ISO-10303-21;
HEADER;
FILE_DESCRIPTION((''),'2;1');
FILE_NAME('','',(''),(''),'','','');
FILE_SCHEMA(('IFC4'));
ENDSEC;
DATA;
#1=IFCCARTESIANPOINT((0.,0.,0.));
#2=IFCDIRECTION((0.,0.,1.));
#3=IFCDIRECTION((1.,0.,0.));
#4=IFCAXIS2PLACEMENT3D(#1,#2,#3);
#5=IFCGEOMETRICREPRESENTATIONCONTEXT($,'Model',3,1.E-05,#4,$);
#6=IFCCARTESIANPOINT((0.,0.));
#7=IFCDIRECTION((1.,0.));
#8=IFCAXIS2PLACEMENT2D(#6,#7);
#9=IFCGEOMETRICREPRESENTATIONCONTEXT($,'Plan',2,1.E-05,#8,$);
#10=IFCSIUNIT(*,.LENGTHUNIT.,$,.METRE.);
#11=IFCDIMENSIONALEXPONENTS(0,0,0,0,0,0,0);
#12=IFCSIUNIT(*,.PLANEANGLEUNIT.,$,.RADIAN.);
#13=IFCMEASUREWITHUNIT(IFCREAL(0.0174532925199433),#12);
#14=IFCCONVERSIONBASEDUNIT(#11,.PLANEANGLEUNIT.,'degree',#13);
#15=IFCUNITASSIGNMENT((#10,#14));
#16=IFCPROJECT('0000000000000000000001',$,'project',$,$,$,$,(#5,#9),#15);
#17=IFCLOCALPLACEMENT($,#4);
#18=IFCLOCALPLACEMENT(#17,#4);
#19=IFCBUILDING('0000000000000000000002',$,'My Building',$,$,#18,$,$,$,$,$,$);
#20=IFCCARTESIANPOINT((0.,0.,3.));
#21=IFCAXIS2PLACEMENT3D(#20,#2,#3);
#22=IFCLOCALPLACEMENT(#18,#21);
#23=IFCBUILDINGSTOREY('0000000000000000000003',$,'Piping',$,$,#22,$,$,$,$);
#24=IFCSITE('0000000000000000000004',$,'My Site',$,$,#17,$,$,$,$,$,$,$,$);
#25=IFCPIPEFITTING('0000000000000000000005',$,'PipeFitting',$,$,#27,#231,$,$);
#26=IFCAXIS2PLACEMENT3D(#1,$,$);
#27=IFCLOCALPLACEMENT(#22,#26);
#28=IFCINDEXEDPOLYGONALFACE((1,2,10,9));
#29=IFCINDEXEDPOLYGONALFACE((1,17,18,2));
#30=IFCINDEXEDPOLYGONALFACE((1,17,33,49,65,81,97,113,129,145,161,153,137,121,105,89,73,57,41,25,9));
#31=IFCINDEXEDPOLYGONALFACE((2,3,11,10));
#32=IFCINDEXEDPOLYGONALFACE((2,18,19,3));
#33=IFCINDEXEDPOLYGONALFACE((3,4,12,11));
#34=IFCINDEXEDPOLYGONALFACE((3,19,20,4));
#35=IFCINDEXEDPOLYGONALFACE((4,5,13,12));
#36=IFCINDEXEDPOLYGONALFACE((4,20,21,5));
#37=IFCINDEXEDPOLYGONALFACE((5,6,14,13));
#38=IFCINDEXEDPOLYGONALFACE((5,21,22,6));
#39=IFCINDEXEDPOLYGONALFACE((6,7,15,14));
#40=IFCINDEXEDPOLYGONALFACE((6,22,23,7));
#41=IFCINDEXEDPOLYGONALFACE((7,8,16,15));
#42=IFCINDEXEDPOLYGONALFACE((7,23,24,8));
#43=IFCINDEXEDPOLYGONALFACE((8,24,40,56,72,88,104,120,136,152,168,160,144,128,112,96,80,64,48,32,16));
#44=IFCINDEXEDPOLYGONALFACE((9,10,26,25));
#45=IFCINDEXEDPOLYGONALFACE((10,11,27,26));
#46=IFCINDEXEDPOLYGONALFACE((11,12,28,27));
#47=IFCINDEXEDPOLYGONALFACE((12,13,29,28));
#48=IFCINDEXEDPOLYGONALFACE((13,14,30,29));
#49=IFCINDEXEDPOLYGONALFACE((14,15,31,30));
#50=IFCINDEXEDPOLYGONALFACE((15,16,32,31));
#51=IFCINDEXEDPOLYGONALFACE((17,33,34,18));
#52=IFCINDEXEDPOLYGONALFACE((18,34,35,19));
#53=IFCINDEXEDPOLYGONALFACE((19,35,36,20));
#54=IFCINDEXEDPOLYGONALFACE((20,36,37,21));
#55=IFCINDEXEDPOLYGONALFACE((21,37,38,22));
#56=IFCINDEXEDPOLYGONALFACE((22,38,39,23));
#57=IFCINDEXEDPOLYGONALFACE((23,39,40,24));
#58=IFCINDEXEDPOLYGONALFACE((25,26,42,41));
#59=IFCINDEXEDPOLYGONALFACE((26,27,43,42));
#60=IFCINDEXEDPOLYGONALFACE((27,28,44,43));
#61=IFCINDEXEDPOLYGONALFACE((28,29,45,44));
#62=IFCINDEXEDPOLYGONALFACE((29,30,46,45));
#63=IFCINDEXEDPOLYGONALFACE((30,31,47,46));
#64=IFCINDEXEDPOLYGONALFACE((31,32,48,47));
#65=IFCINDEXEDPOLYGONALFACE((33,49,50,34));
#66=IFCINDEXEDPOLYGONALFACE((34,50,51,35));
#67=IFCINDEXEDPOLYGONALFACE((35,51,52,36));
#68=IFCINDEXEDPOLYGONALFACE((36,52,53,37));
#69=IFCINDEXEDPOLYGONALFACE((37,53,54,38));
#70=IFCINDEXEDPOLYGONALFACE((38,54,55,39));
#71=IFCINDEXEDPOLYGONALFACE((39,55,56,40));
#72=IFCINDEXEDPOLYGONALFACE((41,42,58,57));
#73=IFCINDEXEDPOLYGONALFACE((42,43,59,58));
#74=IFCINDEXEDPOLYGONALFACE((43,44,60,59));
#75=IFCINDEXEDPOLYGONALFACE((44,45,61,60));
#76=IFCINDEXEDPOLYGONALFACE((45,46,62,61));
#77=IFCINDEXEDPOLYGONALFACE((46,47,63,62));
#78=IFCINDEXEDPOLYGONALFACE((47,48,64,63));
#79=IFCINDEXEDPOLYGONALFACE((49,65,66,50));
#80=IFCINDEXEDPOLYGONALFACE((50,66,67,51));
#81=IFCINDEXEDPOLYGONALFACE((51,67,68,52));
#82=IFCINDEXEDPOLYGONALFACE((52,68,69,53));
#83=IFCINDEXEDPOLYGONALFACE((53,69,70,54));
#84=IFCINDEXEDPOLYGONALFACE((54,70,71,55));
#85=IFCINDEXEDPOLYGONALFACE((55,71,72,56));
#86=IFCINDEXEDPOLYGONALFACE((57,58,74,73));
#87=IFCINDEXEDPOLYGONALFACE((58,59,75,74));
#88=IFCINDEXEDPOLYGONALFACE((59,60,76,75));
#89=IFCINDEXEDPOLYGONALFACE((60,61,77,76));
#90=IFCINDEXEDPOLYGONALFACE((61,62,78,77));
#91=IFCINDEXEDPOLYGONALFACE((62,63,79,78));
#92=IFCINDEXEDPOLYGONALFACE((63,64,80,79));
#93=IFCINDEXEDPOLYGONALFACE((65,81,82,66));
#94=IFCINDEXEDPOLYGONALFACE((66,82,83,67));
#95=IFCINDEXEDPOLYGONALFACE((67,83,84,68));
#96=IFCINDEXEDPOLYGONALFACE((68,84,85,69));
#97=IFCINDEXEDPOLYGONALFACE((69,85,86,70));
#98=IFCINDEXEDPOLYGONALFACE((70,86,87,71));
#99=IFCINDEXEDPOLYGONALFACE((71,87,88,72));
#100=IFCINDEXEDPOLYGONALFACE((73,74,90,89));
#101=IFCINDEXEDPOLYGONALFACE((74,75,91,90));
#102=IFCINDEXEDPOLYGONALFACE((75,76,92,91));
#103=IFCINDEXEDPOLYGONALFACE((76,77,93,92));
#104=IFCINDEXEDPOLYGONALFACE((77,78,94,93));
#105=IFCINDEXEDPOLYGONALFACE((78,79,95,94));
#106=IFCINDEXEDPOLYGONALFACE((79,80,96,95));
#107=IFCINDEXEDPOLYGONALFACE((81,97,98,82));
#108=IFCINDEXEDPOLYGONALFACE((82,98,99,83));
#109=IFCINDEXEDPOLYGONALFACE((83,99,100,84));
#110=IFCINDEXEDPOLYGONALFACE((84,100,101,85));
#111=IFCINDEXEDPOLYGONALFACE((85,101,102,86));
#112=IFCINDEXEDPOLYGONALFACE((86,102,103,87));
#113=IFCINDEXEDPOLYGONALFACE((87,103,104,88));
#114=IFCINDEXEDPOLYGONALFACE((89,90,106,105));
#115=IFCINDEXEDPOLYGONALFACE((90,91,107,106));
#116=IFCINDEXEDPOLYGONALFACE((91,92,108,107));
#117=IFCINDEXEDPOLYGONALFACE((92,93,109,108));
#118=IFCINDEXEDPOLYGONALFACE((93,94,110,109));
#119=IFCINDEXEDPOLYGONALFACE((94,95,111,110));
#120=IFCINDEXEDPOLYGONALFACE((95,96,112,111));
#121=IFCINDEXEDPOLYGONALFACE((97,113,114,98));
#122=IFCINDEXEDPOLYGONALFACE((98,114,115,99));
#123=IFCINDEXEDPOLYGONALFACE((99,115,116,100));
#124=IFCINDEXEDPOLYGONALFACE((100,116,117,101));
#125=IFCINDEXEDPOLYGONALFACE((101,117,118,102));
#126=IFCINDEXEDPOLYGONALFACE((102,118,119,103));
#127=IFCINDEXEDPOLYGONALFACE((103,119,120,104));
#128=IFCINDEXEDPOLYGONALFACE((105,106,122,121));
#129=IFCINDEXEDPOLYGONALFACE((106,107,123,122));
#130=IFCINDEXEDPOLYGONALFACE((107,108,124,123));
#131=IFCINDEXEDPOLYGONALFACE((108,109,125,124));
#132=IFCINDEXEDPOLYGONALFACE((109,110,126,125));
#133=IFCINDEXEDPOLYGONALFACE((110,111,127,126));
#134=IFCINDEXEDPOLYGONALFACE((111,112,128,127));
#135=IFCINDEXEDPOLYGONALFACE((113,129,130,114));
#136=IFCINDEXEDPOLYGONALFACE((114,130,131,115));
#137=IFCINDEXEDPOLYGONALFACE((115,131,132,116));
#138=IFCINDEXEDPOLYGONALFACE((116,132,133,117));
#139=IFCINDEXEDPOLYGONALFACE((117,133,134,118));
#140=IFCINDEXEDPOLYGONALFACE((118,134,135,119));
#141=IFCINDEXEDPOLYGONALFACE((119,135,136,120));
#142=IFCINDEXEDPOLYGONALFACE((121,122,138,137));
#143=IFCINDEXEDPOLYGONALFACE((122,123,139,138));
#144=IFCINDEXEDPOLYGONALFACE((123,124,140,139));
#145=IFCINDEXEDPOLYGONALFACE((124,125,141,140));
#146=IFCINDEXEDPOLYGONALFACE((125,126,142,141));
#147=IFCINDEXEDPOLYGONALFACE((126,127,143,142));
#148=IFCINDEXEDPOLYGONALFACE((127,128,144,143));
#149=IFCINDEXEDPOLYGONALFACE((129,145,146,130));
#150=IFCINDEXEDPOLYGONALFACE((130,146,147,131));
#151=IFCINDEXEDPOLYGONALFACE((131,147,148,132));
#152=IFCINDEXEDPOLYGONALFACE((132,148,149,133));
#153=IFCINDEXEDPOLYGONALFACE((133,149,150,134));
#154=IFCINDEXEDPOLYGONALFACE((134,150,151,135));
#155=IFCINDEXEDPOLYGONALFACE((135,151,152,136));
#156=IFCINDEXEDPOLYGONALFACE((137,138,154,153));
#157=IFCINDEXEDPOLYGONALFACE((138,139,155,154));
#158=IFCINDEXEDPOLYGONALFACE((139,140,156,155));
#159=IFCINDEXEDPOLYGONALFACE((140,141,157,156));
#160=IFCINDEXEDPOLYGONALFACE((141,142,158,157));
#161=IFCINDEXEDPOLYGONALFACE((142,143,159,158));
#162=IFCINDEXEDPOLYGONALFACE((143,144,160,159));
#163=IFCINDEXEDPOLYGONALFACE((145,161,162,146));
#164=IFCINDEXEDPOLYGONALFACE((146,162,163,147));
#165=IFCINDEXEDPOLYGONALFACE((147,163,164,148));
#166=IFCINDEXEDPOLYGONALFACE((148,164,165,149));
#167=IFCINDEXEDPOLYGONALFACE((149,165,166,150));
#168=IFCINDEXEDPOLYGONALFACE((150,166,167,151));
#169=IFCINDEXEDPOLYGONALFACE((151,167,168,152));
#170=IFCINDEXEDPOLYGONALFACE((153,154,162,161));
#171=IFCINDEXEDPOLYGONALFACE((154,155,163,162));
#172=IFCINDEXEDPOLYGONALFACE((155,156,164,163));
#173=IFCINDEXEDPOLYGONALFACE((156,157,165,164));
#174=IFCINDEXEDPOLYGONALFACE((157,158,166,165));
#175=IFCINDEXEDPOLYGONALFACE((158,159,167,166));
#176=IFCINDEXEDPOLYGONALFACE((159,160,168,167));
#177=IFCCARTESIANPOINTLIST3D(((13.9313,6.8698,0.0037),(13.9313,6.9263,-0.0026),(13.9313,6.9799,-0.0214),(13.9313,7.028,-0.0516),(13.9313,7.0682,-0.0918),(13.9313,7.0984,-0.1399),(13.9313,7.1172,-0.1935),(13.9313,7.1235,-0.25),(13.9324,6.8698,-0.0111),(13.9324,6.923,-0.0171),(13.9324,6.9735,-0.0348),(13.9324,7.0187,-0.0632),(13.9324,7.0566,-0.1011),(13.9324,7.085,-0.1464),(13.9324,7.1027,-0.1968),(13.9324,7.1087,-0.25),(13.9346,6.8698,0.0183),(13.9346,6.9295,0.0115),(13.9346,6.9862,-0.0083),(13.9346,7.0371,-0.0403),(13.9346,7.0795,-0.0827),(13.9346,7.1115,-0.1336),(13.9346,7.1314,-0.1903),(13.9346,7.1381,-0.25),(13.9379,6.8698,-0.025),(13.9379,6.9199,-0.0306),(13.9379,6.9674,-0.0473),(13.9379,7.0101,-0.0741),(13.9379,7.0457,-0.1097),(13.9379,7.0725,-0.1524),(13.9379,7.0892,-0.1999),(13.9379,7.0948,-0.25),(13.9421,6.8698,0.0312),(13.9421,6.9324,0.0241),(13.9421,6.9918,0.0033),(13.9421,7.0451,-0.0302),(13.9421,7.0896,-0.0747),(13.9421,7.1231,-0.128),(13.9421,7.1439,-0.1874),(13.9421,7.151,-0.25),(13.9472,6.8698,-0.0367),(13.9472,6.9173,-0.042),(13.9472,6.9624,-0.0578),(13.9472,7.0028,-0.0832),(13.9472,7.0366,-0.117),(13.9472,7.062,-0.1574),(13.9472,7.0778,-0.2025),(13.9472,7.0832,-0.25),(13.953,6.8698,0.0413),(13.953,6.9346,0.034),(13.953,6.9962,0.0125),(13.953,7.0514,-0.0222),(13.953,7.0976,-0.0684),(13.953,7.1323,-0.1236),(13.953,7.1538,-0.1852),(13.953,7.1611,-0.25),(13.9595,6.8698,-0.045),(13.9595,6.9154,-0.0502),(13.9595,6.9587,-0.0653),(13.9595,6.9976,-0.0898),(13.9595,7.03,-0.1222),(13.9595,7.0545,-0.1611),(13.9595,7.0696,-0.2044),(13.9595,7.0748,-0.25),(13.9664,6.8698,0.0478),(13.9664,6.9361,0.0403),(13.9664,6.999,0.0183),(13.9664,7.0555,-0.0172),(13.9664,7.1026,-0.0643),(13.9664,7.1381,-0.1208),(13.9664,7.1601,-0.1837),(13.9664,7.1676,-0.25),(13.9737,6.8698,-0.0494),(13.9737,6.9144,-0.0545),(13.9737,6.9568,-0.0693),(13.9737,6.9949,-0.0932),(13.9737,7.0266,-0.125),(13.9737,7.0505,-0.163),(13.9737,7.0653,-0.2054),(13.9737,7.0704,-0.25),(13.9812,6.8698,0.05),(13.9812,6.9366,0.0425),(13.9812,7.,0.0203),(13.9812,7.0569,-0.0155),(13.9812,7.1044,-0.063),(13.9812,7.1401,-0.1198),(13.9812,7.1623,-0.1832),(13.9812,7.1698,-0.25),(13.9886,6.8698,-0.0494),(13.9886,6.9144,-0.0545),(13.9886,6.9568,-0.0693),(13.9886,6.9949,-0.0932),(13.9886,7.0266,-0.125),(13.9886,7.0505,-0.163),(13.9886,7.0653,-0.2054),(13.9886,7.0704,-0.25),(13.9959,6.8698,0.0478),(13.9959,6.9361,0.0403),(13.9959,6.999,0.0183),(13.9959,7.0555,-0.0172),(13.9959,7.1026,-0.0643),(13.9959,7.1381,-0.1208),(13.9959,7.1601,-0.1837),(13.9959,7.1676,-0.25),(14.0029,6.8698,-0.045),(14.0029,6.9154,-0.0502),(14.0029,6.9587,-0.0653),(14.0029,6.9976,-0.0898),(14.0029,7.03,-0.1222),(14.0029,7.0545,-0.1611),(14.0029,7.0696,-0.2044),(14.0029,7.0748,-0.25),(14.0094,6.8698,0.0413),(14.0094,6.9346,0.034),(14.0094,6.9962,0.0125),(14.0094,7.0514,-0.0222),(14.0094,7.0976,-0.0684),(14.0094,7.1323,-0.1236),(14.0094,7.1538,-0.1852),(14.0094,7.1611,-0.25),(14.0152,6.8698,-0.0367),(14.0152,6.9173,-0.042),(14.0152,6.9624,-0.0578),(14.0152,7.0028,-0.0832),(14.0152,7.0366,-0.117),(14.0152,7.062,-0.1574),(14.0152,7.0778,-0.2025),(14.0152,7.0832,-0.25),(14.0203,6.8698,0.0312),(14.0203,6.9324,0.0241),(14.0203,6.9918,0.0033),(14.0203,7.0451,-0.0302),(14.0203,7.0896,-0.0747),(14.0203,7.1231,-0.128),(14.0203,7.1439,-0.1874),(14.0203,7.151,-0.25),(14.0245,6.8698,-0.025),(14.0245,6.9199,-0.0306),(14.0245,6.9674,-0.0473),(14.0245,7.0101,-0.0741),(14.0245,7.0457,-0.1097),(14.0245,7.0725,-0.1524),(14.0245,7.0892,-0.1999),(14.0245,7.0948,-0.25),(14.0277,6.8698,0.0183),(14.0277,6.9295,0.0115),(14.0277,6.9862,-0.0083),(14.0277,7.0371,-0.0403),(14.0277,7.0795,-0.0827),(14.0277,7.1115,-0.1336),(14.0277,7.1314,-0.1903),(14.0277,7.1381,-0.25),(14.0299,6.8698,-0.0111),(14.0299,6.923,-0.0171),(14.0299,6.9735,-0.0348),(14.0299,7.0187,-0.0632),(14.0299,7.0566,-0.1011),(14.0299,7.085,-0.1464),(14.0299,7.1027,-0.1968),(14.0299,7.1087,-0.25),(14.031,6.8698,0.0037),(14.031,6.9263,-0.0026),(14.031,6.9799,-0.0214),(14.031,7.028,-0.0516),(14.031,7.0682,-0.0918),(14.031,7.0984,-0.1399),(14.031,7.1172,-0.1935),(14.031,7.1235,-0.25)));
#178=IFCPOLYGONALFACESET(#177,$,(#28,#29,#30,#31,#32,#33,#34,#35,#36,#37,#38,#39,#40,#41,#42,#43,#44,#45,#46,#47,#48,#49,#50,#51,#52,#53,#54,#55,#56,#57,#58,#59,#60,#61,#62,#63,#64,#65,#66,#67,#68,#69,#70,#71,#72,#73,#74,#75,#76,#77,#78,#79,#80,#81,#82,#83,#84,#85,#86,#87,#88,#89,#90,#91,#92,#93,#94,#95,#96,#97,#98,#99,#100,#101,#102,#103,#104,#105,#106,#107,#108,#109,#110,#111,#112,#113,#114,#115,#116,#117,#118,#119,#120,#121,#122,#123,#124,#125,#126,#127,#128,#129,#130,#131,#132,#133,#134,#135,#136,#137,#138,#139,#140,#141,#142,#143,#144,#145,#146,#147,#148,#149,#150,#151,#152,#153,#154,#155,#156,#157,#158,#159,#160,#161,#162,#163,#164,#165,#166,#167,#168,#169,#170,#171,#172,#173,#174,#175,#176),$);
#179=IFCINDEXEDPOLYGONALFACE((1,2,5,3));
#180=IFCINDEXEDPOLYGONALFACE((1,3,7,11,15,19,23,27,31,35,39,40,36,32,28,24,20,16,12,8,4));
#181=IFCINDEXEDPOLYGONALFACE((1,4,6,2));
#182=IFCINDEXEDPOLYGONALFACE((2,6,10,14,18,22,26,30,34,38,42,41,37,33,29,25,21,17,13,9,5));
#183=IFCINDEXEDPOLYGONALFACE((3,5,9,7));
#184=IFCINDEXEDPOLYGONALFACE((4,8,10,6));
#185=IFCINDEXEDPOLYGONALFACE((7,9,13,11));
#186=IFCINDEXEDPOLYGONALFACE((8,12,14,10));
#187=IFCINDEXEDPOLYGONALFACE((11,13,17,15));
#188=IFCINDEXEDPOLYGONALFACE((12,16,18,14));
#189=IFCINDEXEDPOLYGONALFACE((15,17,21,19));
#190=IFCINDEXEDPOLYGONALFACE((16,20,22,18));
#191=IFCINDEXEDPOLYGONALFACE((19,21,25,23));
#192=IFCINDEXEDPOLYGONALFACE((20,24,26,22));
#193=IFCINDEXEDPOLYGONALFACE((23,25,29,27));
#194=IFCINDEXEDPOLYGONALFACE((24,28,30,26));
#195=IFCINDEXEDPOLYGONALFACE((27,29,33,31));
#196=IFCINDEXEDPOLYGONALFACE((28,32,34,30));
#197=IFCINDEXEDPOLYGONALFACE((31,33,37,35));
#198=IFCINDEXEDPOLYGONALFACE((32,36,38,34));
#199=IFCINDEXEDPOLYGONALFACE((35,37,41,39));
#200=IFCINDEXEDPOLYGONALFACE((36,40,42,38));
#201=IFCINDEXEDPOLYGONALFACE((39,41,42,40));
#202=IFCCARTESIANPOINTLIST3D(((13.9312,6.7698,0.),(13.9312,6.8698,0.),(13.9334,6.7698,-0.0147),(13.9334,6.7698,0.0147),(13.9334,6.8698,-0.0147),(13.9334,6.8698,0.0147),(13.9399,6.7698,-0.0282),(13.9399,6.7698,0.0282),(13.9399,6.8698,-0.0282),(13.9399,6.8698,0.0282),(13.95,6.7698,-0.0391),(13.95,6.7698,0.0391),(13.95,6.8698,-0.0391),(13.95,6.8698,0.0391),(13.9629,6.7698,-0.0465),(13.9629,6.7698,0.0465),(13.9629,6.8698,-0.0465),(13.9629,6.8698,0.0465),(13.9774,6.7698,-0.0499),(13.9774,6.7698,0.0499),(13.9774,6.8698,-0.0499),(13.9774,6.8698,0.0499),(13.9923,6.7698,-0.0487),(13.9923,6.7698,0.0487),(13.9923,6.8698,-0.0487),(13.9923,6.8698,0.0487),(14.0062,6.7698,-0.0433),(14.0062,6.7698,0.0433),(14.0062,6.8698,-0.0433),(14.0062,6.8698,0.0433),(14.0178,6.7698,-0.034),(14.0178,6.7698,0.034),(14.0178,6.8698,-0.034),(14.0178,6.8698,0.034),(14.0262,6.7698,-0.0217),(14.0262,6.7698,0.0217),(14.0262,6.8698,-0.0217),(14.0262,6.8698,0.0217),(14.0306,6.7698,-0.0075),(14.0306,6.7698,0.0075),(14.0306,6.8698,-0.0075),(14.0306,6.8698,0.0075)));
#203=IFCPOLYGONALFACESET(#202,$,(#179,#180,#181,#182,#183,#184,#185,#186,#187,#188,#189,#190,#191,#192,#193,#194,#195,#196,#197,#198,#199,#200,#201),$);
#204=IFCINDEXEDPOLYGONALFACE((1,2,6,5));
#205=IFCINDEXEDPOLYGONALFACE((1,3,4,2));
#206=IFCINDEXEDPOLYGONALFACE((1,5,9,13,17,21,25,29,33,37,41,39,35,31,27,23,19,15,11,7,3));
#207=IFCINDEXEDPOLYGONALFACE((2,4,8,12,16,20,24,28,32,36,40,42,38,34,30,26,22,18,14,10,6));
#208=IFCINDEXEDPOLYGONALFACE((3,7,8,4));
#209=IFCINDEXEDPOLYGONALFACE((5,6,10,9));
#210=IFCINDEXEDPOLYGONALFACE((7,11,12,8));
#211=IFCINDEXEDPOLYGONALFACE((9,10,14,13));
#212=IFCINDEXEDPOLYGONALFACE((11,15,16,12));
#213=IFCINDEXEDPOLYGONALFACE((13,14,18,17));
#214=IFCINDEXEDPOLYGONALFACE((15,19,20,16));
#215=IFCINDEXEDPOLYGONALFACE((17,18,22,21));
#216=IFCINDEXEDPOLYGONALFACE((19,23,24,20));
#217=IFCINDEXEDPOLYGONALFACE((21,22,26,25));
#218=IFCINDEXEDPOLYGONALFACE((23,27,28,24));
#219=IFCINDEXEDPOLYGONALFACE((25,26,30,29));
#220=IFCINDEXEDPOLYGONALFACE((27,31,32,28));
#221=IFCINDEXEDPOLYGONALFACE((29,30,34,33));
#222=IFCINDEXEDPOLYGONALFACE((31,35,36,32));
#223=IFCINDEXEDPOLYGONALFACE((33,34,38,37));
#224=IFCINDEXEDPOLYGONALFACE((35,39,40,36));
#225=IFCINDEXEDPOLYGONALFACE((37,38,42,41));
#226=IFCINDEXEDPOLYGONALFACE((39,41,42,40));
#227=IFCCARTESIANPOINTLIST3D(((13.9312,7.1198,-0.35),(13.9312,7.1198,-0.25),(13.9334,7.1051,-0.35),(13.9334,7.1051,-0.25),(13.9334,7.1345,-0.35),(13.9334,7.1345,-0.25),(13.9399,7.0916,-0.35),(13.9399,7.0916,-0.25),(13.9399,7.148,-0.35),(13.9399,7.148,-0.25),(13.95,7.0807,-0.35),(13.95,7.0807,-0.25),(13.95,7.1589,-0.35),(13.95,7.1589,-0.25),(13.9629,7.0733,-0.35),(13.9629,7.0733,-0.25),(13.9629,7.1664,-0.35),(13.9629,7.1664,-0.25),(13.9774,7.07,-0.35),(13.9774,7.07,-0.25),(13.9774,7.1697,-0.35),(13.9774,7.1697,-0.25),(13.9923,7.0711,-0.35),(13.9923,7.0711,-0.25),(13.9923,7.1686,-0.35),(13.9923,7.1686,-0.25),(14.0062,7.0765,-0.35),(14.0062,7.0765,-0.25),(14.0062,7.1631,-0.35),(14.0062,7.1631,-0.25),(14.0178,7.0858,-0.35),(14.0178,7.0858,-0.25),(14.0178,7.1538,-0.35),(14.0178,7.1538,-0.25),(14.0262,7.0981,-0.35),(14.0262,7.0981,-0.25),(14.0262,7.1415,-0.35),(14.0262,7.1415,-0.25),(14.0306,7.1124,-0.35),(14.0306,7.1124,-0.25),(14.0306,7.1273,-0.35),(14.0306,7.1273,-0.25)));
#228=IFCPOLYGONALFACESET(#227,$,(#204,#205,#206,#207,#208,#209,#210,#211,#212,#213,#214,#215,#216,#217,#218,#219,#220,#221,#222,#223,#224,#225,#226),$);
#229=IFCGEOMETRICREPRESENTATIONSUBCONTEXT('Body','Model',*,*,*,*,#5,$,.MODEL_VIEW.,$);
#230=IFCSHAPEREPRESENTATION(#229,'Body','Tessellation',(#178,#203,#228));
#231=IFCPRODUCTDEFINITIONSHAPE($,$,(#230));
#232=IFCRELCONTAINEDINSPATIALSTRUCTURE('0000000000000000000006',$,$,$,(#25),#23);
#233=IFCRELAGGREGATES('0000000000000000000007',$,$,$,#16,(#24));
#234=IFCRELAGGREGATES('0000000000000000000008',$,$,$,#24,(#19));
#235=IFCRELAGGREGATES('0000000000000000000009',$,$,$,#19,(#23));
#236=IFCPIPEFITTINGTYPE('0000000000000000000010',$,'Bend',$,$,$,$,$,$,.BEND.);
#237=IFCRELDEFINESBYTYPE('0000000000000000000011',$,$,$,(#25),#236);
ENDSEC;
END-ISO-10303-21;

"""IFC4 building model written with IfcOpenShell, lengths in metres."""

from ifc_helpers import new_model, entity, si_unit, converted_unit, frame, origin_with_axes, origin_2d_with_axis, place, context, subcontext, project, spatial, line, indexed_curve, circle, outline, extrude, source, transform, mapped, type_object, type_shapes, element, save


model = new_model("IFC4")

# Units and contexts
model_context = context("Model", 3, precision=1e-05, world=origin_with_axes())
plan_context = context("Plan", 2, precision=1e-05, world=origin_2d_with_axis())
body_context = subcontext(model_context, "Body", "Model", "MODEL_VIEW")
ifc_project = project(units=[si_unit("LENGTHUNIT", "METRE"), converted_unit("PLANEANGLEUNIT", "degree", entity("IfcReal", 0.0174532925199433), si_unit("PLANEANGLEUNIT", "RADIAN"), dimensions=[0, 0, 0, 0, 0, 0, 0])], contexts=[model_context, plan_context])

# Site, building, storey
site_placement = place(None, origin_with_axes())
site = spatial("IfcSite", under=ifc_project, at=site_placement, Name="My Site")
building_placement = place(site_placement, origin_with_axes())
building = spatial("IfcBuilding", under=site, at=building_placement, Name="My Building")
storey_placement = place(building_placement, frame((0.0, 0.0, 3.0), z_axis=(0.0, 0.0, 1.0), x_axis=(1.0, 0.0, 0.0)))
storey = spatial("IfcBuildingStorey", under=building, at=storey_placement, Name="Piping")

# Pipe fitting, opening
pipe_fitting_type = type_object("IfcPipeFittingType", Name="Bend", PredefinedType="BEND")
shared_shape = source(origin_with_axes(), body_context, "Body", "SolidModel", [
    entity("IfcSweptDiskSolid", entity("IfcIndexedPolyCurve", entity("IfcCartesianPointList3D", [[0.0, 0.0, 0.1], [0.0, -0.0732, 0.2768], [0.0, -0.25, 0.35]]), [entity("IfcArcIndex", [1, 2, 3])]), 0.05),
    extrude(circle(Radius=0.05), origin_with_axes(), (0.0, 0.0, 1.0), 0.1),
    extrude(circle(Radius=0.05), frame((0.0, -0.25, 0.35), z_axis=(0.0, -1.0, 0.0), x_axis=(1.0, 0.0, 0.0)), (0.0, 0.0, 1.0), 0.1),
])
type_shapes(pipe_fitting_type, [shared_shape])
pipe_fitting_1_placement = place(storey_placement, frame((13.9812, 6.7698, 0.0), z_axis=(0.0, 1.0, 0.0), x_axis=(-1.0, 0.0, 0.0)))
pipe_fitting_1 = element("IfcPipeFitting", 1, at=pipe_fitting_1_placement, inside=storey, type_object=pipe_fitting_type, Name="PipeFitting", context=body_context, shape_type="MappedRepresentation", body=[
    mapped(shared_shape, transform((0.0, 0.0, 0.0), x_axis=(1.0, 0.0, 0.0), y_axis=(0.0, 1.0, 0.0), z_axis=(0.0, 0.0, 1.0), scale=1.0)),
])
opening_1_placement = place(pipe_fitting_1_placement, frame((13.9812, -3.0, -6.7698), z_axis=(0.0, 1.0, 0.0), x_axis=(-1.0, 0.0, 0.0)))
element("IfcOpeningElement", 2, at=opening_1_placement, cuts=pipe_fitting_1, PredefinedType="OPENING", context=body_context, shape_type="SweptSolid", body=[
    extrude(outline(indexed_curve([(0.0, 0.0), (0.5, 0.0), (0.5, 0.5), (0.0, 0.5)], segments=[line(1, 2, 3, 4, 1)])), origin_with_axes(), (0.0, 0.0, 1.0), 0.5),
])

save(model, "model.ifc")
